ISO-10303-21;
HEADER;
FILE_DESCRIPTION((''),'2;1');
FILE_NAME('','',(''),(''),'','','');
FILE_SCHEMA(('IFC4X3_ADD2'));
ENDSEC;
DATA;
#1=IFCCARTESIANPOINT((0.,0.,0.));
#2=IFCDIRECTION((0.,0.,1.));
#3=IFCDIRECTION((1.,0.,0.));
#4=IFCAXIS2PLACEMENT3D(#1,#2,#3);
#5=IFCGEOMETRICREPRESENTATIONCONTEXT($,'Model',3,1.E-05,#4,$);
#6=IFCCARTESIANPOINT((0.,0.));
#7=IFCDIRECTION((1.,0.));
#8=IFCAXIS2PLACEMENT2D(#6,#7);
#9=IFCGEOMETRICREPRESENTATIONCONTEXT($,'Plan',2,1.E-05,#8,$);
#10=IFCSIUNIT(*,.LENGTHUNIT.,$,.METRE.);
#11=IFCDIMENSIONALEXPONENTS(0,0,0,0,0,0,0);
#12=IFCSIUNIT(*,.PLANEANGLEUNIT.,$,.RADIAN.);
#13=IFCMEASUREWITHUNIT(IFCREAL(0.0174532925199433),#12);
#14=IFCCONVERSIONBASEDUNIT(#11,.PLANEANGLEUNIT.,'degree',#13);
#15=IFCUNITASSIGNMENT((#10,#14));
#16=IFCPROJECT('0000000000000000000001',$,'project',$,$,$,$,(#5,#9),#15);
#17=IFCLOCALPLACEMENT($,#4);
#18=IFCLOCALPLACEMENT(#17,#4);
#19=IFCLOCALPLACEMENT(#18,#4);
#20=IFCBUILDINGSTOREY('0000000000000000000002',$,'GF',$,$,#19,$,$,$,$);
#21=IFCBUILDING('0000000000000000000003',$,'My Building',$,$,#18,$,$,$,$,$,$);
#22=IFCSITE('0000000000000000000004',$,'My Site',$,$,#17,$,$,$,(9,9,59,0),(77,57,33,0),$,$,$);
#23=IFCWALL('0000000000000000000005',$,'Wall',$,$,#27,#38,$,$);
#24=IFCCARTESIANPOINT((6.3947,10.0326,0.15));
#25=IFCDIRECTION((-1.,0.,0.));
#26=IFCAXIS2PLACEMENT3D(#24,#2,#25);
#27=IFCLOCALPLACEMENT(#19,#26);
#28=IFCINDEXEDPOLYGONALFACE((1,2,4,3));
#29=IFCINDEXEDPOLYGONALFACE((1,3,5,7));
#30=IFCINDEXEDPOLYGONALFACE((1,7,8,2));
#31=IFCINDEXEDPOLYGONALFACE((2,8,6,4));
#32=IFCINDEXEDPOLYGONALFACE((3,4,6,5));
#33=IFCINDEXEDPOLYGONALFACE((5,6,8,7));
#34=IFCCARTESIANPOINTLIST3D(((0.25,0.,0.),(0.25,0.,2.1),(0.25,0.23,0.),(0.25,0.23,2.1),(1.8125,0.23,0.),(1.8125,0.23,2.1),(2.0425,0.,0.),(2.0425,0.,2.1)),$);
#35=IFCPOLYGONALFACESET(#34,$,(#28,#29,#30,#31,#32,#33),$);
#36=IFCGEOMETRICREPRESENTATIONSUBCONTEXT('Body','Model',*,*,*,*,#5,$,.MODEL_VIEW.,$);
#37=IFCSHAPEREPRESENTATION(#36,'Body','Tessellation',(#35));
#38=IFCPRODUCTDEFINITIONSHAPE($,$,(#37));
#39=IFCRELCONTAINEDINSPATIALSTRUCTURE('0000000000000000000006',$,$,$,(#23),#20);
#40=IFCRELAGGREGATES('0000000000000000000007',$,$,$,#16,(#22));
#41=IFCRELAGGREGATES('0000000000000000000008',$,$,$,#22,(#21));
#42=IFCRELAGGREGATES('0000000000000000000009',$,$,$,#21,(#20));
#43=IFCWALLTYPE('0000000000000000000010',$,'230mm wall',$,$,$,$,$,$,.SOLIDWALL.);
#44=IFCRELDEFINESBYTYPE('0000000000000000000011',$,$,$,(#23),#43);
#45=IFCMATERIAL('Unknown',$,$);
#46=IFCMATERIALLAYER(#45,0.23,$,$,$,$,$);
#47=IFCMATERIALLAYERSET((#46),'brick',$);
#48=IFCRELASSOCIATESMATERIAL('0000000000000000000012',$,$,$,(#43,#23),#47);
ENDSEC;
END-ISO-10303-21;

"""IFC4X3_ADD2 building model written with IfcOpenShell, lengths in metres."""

from ifc_helpers import new_model, entity, si_unit, converted_unit, frame, origin_with_axes, origin_2d_with_axis, place, context, subcontext, project, spatial, line, indexed_curve, outline, extrude, material, layer, layer_set, layer_usage, type_object, element, save


model = new_model("IFC4X3_ADD2")

# Units and contexts
model_context = context("Model", 3, precision=1e-05, world=origin_with_axes())
plan_context = context("Plan", 2, precision=1e-05, world=origin_2d_with_axis())
body_context_1 = subcontext(model_context, "Body", "Model", "MODEL_VIEW")
ifc_project = project(units=[si_unit("LENGTHUNIT", "METRE"), converted_unit("PLANEANGLEUNIT", "degree", entity("IfcReal", 0.0174532925199433), si_unit("PLANEANGLEUNIT", "RADIAN"), dimensions=[0, 0, 0, 0, 0, 0, 0])], contexts=[model_context, plan_context])

# Site, building, storey
site_placement = place(None, origin_with_axes())
site = spatial("IfcSite", under=ifc_project, at=site_placement, Name="My Site", RefLatitude=(9, 9, 59, 0), RefLongitude=(77, 57, 33, 0))
building_placement = place(site_placement, origin_with_axes())
building = spatial("IfcBuilding", under=site, at=building_placement, Name="My Building")
storey_placement = place(building_placement, origin_with_axes())
storey = spatial("IfcBuildingStorey", under=building, at=storey_placement, Name="GF")

# Shared definitions
ifc_material = material(Name="Unknown")

# Wall
ifc_layer_1 = layer(ifc_material, 0.23)
ifc_layer_set_1 = layer_set([ifc_layer_1], Name="brick")
wall_type_1 = type_object("IfcWallType", Name="230mm wall", PredefinedType="SOLIDWALL", material=ifc_layer_set_1)
ifc_layer_usage_1 = layer_usage(ifc_layer_set_1, "AXIS2", "POSITIVE", 0.0)
wall_1_placement = place(storey_placement, frame((6.3947, 10.0326, 0.15), z_axis=(0.0, 0.0, 1.0), x_axis=(-1.0, 0.0, 0.0)))
element("IfcWall", 1, at=wall_1_placement, inside=storey, type_object=wall_type_1, material=ifc_layer_usage_1, Name="Wall", context=body_context_1, shape_type="SweptSolid", body=[
    extrude(outline(indexed_curve([(0.25, 0.0), (0.25, 0.23), (1.8125, 0.23), (2.0425, 0.0)], segments=[line(1, 2, 3, 4, 1)])), origin_with_axes(), (0.0, 0.0, 1.0), 2.1),
])

save(model, "model.ifc")
